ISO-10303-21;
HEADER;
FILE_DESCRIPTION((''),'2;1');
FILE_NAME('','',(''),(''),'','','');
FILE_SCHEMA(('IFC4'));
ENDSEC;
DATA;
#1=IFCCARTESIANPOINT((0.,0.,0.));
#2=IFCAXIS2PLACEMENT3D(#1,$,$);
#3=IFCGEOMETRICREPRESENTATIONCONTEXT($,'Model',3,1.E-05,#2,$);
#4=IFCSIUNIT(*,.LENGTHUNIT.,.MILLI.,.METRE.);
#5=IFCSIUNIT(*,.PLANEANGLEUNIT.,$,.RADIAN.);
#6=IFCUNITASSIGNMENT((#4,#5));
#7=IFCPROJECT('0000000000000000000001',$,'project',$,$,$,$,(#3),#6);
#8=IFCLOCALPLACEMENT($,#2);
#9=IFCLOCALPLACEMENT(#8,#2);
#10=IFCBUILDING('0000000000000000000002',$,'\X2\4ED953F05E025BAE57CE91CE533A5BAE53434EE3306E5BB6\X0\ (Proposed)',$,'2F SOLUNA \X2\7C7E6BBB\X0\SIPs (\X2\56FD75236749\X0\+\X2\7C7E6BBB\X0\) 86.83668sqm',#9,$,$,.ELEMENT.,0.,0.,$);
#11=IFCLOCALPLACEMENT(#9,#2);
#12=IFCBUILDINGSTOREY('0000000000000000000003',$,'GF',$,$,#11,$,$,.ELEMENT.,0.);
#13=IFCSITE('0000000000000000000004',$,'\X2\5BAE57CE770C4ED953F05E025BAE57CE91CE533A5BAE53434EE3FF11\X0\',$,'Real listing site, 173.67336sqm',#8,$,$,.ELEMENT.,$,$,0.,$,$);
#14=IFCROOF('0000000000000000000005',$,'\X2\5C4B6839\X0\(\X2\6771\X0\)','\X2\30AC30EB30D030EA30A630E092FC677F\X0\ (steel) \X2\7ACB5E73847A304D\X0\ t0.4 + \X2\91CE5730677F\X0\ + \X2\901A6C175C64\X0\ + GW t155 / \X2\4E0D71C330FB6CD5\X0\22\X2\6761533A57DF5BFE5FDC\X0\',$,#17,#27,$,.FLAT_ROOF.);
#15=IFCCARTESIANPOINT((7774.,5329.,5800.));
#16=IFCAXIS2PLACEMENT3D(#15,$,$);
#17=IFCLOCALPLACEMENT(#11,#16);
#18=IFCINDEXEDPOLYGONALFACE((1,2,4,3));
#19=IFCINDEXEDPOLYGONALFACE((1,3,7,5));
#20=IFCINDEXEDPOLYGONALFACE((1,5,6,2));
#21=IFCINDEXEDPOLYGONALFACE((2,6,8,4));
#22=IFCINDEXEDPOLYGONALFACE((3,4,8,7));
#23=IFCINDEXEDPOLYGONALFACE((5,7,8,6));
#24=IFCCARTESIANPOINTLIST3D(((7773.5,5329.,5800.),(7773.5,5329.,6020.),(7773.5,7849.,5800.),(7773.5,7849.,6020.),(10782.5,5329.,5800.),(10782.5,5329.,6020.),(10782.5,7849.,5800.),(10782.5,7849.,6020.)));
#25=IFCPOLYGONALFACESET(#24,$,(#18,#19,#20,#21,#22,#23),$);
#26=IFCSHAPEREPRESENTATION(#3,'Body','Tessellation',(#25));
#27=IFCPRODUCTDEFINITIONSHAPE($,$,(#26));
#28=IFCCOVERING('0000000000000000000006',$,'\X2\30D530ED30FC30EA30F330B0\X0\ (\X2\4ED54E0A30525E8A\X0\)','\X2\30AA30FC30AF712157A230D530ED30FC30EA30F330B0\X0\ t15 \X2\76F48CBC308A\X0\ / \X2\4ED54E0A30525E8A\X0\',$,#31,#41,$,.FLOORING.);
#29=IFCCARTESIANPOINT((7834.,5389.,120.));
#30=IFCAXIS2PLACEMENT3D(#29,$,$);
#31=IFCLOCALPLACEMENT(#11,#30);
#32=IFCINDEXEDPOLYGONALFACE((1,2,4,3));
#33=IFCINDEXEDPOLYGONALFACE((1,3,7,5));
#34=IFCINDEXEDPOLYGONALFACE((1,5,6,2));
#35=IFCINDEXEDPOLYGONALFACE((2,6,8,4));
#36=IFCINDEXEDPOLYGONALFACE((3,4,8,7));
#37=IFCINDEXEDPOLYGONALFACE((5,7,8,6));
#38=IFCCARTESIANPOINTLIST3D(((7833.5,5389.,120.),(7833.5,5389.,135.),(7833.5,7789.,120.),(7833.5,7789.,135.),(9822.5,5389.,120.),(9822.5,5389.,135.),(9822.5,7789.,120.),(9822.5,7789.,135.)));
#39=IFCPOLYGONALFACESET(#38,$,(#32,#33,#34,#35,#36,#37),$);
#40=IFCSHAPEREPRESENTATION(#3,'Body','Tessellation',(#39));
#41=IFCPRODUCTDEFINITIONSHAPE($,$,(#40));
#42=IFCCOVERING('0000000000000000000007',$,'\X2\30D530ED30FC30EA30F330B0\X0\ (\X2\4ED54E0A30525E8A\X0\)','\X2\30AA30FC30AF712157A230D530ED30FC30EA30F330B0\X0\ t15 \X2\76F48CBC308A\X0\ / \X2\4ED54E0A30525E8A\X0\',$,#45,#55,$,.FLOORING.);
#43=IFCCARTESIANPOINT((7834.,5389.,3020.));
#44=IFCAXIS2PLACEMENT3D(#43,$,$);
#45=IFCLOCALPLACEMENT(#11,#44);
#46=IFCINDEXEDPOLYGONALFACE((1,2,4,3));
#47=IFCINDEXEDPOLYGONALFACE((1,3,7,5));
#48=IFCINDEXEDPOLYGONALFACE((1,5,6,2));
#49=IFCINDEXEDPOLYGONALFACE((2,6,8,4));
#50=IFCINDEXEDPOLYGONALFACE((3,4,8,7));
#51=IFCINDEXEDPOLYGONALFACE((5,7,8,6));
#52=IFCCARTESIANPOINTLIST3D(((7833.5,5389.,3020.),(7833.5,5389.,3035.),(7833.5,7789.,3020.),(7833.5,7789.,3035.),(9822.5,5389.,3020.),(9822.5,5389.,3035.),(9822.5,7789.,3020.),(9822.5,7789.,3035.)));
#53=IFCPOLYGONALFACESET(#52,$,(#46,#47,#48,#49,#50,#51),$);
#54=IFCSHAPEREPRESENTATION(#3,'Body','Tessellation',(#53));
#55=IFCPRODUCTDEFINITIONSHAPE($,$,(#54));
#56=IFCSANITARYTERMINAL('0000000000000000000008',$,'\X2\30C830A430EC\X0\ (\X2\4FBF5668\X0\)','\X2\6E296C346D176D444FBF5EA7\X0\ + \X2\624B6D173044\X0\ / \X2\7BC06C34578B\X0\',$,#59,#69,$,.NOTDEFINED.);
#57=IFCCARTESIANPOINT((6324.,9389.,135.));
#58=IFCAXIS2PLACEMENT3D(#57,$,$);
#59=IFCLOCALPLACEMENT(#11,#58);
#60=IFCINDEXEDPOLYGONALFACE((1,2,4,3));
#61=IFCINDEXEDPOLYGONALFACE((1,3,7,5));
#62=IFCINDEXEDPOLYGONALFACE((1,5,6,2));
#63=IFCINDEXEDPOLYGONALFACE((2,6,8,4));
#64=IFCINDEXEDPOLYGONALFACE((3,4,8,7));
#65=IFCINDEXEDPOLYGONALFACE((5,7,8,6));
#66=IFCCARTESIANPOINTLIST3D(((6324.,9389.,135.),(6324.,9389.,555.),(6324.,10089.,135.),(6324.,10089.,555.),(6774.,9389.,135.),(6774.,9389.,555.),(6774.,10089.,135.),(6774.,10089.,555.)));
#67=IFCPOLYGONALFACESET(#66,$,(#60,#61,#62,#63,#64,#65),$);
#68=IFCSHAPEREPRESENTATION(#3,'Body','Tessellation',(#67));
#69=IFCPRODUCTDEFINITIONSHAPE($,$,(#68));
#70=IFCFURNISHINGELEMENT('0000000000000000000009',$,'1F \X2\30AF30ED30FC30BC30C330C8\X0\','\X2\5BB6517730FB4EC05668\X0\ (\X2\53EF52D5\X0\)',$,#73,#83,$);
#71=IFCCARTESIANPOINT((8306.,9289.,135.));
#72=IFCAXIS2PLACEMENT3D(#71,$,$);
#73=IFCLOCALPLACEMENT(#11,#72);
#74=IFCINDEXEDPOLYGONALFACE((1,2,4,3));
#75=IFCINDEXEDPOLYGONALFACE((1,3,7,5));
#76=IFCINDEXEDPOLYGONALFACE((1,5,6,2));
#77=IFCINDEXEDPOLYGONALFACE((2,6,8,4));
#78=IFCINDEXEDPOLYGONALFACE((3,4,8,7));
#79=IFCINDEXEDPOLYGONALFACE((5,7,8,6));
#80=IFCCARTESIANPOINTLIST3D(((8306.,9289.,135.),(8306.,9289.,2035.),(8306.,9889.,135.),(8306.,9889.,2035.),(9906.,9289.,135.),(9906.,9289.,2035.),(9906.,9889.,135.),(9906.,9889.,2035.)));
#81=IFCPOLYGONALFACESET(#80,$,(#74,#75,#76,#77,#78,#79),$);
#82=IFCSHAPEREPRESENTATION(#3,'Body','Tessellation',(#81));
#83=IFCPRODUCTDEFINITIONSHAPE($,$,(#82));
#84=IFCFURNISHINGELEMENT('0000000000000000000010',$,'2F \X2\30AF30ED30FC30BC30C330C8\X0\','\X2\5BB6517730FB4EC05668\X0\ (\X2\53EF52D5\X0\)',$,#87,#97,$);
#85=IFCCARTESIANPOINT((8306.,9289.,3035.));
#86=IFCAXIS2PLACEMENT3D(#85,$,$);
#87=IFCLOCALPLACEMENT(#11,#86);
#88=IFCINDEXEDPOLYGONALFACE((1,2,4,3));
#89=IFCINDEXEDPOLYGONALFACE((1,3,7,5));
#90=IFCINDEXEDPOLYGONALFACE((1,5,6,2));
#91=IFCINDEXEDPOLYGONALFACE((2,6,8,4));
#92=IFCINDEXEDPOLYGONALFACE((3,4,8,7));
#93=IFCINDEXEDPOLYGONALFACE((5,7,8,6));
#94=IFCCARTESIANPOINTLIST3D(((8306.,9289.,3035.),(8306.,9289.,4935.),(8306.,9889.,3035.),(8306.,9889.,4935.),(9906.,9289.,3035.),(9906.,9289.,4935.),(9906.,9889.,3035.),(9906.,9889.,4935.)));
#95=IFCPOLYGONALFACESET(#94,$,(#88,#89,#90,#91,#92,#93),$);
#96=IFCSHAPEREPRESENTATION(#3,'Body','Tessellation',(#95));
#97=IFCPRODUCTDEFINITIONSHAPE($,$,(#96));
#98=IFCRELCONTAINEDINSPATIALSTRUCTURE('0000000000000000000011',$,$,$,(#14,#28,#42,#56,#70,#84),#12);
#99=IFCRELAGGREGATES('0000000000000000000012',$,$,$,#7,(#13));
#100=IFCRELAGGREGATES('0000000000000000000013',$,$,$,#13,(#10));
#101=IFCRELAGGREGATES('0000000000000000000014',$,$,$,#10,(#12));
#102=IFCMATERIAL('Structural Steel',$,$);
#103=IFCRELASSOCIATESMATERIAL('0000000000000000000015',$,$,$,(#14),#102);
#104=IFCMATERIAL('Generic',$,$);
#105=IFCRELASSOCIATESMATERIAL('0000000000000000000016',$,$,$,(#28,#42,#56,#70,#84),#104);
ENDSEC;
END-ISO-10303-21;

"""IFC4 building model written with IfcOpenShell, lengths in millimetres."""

from ifc_helpers import new_model, si_unit, frame, frame_2d, origin, place, context, project, spatial, rectangle, extrude, material, element, save


model = new_model("IFC4")

# Units and contexts
model_context = context("Model", 3, precision=1e-05, world=origin())
ifc_project = project(units=[si_unit("LENGTHUNIT", "METRE", prefix="MILLI"), si_unit("PLANEANGLEUNIT", "RADIAN")], contexts=[model_context])

# Site, building, storey
site_placement = place(None, origin())
site = spatial("IfcSite", under=ifc_project, at=site_placement, Name="宮城県仙台市宮城野区宮千代１", ObjectType="Real listing site, 173.67336sqm", CompositionType="ELEMENT", RefElevation=0.0)
building_placement = place(site_placement, origin())
building = spatial("IfcBuilding", under=site, at=building_placement, Name="仙台市宮城野区宮千代の家 (Proposed)", ObjectType="2F SOLUNA 籾殻SIPs (国産杉+籾殻) 86.83668sqm", CompositionType="ELEMENT", ElevationOfRefHeight=0.0, ElevationOfTerrain=0.0)
storey_placement = place(building_placement, origin())
storey = spatial("IfcBuildingStorey", under=building, at=storey_placement, Name="GF", CompositionType="ELEMENT", Elevation=0.0)

# Roof
ifc_material_1 = material(Name="Structural Steel")
roof_placement = place(storey_placement, frame((7774.0, 5329.0, 5800.0)))
element("IfcRoof", 1, at=roof_placement, inside=storey, material=ifc_material_1, Name="屋根(東)", Description="ガルバリウム鋼板 (steel) 立平葺き t0.4 + 野地板 + 通気層 + GW t155 / 不燃・法22条区域対応", PredefinedType="FLAT_ROOF", context=model_context, shape_type="SweptSolid", body=[
    extrude(rectangle(XDim=3009.0, YDim=2520.0, at=frame_2d((1504.0, 1260.0))), frame((7774.0, 5329.0, 5800.0)), (0.0, 0.0, 1.0), 220.0),
])

# Coverings
ifc_material_2 = material(Name="Generic")
covering_1_placement = place(storey_placement, frame((7834.0, 5389.0, 120.0)))
element("IfcCovering", 2, at=covering_1_placement, inside=storey, material=ifc_material_2, Name="フローリング (仕上げ床)", Description="オーク無垢フローリング t15 直貼り / 仕上げ床", PredefinedType="FLOORING", context=model_context, shape_type="SweptSolid", body=[
    extrude(rectangle(XDim=1989.0, YDim=2400.0, at=frame_2d((994.0, 1200.0))), frame((7834.0, 5389.0, 120.0)), (0.0, 0.0, 1.0), 15.0),
])
covering_2_placement = place(storey_placement, frame((7834.0, 5389.0, 3020.0)))
element("IfcCovering", 3, at=covering_2_placement, inside=storey, material=ifc_material_2, Name="フローリング (仕上げ床)", Description="オーク無垢フローリング t15 直貼り / 仕上げ床", PredefinedType="FLOORING", context=model_context, shape_type="SweptSolid", body=[
    extrude(rectangle(XDim=1989.0, YDim=2400.0, at=frame_2d((994.0, 1200.0))), frame((7834.0, 5389.0, 3020.0)), (0.0, 0.0, 1.0), 15.0),
])

# Sanitary terminal
sanitary_terminal_placement = place(storey_placement, frame((6324.0, 9389.0, 135.0)))
element("IfcSanitaryTerminal", 4, at=sanitary_terminal_placement, inside=storey, material=ifc_material_2, Name="トイレ (便器)", Description="温水洗浄便座 + 手洗い / 節水型", PredefinedType="NOTDEFINED", context=model_context, shape_type="SweptSolid", body=[
    extrude(rectangle(XDim=450.0, YDim=700.0, at=frame_2d((225.0, 350.0))), frame((6324.0, 9389.0, 135.0)), (0.0, 0.0, 1.0), 420.0),
])

# Furnishing elements
furnishing_1_placement = place(storey_placement, frame((8306.0, 9289.0, 135.0)))
element("IfcFurnishingElement", 5, at=furnishing_1_placement, inside=storey, material=ifc_material_2, Name="1F クローゼット", Description="家具・什器 (可動)", context=model_context, shape_type="SweptSolid", body=[
    extrude(rectangle(XDim=1600.0, YDim=600.0, at=frame_2d((800.0, 300.0))), frame((8306.0, 9289.0, 135.0)), (0.0, 0.0, 1.0), 1900.0),
])
furnishing_2_placement = place(storey_placement, frame((8306.0, 9289.0, 3035.0)))
element("IfcFurnishingElement", 6, at=furnishing_2_placement, inside=storey, material=ifc_material_2, Name="2F クローゼット", Description="家具・什器 (可動)", context=model_context, shape_type="SweptSolid", body=[
    extrude(rectangle(XDim=1600.0, YDim=600.0, at=frame_2d((800.0, 300.0))), frame((8306.0, 9289.0, 3035.0)), (0.0, 0.0, 1.0), 1900.0),
])

save(model, "model.ifc")
